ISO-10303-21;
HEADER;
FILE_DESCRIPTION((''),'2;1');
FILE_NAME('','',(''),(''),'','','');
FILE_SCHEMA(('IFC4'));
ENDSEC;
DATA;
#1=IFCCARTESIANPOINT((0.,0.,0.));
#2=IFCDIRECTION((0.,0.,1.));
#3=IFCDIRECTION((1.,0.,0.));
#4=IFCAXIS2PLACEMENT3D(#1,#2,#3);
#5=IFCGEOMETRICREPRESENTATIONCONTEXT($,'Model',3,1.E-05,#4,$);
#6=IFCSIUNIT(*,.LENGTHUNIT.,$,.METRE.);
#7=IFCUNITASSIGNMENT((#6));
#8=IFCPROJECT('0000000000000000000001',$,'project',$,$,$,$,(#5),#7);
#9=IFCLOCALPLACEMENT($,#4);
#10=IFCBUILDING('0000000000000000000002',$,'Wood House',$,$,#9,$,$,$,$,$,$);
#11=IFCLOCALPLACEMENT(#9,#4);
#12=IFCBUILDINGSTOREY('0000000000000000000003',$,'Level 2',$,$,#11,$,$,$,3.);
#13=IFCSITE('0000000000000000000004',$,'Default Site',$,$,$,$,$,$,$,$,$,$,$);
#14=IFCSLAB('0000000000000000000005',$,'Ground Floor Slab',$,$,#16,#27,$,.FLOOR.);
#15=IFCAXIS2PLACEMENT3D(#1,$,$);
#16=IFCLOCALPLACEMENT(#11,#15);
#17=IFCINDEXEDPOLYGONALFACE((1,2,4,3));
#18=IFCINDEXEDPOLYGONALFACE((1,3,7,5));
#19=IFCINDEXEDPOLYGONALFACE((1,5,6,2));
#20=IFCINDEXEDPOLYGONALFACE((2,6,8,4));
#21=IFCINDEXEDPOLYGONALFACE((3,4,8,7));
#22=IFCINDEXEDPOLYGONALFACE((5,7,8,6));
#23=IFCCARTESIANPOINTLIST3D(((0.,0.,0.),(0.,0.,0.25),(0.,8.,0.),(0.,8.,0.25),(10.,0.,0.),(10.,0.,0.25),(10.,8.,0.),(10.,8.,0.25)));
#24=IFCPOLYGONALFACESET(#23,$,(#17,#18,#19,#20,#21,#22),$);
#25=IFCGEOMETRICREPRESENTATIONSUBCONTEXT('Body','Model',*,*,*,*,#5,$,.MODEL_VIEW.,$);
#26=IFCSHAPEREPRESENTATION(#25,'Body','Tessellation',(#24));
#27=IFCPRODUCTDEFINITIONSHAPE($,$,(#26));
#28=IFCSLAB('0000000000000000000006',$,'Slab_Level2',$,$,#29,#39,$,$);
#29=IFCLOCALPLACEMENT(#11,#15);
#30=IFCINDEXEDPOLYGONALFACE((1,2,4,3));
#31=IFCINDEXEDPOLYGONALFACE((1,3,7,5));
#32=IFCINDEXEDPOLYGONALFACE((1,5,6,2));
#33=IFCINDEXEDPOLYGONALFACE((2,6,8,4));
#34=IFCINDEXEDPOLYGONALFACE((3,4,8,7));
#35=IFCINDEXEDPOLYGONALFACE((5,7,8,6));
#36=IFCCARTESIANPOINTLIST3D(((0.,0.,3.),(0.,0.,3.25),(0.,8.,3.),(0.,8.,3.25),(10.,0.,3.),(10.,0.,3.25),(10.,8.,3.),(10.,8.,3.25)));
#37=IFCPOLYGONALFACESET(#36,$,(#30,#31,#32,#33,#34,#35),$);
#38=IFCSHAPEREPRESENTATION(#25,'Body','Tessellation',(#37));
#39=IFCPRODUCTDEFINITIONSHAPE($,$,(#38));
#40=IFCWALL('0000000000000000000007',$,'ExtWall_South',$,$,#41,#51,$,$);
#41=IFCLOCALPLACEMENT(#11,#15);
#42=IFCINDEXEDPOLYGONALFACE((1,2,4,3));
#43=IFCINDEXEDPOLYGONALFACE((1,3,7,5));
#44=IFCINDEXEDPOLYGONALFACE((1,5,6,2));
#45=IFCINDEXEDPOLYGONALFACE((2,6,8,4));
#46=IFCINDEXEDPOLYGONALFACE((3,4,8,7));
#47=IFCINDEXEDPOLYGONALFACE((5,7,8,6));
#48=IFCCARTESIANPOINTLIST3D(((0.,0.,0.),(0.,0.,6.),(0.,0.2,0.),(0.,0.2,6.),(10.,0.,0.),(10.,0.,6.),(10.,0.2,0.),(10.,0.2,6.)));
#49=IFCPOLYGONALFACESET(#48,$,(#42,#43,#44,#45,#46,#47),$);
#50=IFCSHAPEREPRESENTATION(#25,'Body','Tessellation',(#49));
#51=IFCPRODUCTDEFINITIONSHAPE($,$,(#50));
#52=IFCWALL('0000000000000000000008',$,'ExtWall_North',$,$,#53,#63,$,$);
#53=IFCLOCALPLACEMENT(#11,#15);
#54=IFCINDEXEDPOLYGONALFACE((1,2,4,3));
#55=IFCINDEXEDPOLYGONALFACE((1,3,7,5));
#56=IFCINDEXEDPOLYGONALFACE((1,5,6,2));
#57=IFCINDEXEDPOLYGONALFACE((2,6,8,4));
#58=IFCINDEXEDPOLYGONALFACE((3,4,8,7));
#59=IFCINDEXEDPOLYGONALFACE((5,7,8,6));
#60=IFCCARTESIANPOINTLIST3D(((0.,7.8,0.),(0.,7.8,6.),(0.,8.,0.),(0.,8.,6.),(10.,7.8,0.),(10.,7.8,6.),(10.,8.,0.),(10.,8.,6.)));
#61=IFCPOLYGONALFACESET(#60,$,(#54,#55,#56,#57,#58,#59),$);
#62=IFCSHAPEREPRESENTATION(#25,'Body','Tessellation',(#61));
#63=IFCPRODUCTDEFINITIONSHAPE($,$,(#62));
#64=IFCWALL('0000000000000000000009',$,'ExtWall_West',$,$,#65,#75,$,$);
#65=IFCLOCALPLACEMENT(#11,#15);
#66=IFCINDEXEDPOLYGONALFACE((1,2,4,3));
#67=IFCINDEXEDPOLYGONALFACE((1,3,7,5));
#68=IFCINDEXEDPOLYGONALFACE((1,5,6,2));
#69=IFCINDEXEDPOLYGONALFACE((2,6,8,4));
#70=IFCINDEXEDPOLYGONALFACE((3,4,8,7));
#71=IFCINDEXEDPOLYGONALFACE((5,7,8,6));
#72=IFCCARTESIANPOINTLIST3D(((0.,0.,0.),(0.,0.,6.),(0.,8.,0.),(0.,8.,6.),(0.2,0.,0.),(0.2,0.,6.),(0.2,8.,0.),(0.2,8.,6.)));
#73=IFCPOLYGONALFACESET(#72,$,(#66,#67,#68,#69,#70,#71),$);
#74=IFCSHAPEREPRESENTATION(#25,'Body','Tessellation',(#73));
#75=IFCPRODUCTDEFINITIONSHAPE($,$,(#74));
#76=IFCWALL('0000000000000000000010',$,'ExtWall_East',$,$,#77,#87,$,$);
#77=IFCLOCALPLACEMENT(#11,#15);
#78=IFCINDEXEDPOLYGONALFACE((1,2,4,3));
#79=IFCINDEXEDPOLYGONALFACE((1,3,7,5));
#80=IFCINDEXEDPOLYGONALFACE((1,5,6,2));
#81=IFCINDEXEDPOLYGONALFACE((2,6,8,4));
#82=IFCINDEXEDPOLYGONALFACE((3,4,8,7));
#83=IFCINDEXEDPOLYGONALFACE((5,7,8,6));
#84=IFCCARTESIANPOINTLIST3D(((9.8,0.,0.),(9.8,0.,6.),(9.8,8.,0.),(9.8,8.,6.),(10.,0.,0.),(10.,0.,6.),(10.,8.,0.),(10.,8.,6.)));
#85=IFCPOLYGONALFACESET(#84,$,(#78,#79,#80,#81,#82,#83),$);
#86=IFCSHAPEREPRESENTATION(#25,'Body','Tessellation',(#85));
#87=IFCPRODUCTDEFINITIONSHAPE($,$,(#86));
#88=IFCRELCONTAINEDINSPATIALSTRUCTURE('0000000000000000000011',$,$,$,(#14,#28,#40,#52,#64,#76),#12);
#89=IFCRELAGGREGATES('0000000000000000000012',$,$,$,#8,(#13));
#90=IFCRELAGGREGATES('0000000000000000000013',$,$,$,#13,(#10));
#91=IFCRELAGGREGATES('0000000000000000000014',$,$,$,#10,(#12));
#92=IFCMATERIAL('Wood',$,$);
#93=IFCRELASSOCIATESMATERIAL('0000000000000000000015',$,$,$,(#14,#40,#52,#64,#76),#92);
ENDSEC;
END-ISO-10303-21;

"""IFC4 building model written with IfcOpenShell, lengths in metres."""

from ifc_helpers import new_model, si_unit, frame, origin, origin_with_axes, place, context, subcontext, project, spatial, polyline, indexed_curve, outline, extrude, material, element, save


model = new_model("IFC4")

# Units and contexts
model_context = context("Model", 3, precision=1e-05, world=origin_with_axes())
body_context = subcontext(model_context, "Body", "Model", "MODEL_VIEW")
ifc_project = project(units=[si_unit("LENGTHUNIT", "METRE")], contexts=[model_context])

# Site, building, storey
site = spatial("IfcSite", under=ifc_project, Name="Default Site")
building_placement = place(None, origin_with_axes())
building = spatial("IfcBuilding", under=site, at=building_placement, Name="Wood House")
storey_placement = place(building_placement, origin_with_axes())
storey = spatial("IfcBuildingStorey", under=building, at=storey_placement, Name="Level 2", Elevation=3.0)

# Slabs
ifc_material_1 = material(Name="Wood")
slab_1_placement = place(None, origin_with_axes())
element("IfcSlab", 1, at=slab_1_placement, inside=storey, material=ifc_material_1, Name="Ground Floor Slab", PredefinedType="FLOOR", context=body_context, shape_type="SweptSolid", body=[
    extrude(outline(polyline([(0.0, 0.0), (10.0, 0.0), (10.0, 8.0), (0.0, 8.0), (0.0, 0.0)])), origin(), (0.0, 0.0, 1.0), 0.25),
])
for number, where, z_axis, x_axis, name in (
    (2, (0.0, 0.0, 3.0), (0.0, 0.0, 1.0), (1.0, 0.0, 0.0), "Slab_Level2"),
):
    element("IfcSlab", number, at=place(storey_placement, frame(where, z_axis=z_axis, x_axis=x_axis)), inside=storey, Name=name, context=body_context, shape_type="SweptSolid", body=[
        extrude(outline(indexed_curve([(0.0, 0.0), (10.0, 0.0), (10.0, 8.0), (0.0, 8.0)])), None, (0.0, 0.0, 1.0), 0.25),
    ])

# Walls
for number, where, z_axis, x_axis, name in (
    (3, (0.0, 0.0, 0.0), (0.0, 0.0, 1.0), (1.0, 0.0, 0.0), "ExtWall_South"),
    (4, (0.0, 7.8, 0.0), (0.0, 0.0, 1.0), (1.0, 0.0, 0.0), "ExtWall_North"),
):
    element("IfcWall", number, at=place(None, frame(where, z_axis=z_axis, x_axis=x_axis)), inside=storey, material=ifc_material_1, Name=name, context=body_context, shape_type="SweptSolid", body=[
        extrude(outline(polyline([(0.0, 0.0), (10.0, 0.0), (10.0, 0.2), (0.0, 0.2), (0.0, 0.0)])), origin(), (0.0, 0.0, 1.0), 6.0),
    ])
for number, where, z_axis, x_axis, name in (
    (5, (0.0, 0.0, 0.0), (0.0, 0.0, 1.0), (1.0, 0.0, 0.0), "ExtWall_West"),
    (6, (9.8, 0.0, 0.0), (0.0, 0.0, 1.0), (1.0, 0.0, 0.0), "ExtWall_East"),
):
    element("IfcWall", number, at=place(None, frame(where, z_axis=z_axis, x_axis=x_axis)), inside=storey, material=ifc_material_1, Name=name, context=body_context, shape_type="SweptSolid", body=[
        extrude(outline(polyline([(0.0, 0.0), (0.2, 0.0), (0.2, 8.0), (0.0, 8.0), (0.0, 0.0)])), origin(), (0.0, 0.0, 1.0), 6.0),
    ])

save(model, "model.ifc")
